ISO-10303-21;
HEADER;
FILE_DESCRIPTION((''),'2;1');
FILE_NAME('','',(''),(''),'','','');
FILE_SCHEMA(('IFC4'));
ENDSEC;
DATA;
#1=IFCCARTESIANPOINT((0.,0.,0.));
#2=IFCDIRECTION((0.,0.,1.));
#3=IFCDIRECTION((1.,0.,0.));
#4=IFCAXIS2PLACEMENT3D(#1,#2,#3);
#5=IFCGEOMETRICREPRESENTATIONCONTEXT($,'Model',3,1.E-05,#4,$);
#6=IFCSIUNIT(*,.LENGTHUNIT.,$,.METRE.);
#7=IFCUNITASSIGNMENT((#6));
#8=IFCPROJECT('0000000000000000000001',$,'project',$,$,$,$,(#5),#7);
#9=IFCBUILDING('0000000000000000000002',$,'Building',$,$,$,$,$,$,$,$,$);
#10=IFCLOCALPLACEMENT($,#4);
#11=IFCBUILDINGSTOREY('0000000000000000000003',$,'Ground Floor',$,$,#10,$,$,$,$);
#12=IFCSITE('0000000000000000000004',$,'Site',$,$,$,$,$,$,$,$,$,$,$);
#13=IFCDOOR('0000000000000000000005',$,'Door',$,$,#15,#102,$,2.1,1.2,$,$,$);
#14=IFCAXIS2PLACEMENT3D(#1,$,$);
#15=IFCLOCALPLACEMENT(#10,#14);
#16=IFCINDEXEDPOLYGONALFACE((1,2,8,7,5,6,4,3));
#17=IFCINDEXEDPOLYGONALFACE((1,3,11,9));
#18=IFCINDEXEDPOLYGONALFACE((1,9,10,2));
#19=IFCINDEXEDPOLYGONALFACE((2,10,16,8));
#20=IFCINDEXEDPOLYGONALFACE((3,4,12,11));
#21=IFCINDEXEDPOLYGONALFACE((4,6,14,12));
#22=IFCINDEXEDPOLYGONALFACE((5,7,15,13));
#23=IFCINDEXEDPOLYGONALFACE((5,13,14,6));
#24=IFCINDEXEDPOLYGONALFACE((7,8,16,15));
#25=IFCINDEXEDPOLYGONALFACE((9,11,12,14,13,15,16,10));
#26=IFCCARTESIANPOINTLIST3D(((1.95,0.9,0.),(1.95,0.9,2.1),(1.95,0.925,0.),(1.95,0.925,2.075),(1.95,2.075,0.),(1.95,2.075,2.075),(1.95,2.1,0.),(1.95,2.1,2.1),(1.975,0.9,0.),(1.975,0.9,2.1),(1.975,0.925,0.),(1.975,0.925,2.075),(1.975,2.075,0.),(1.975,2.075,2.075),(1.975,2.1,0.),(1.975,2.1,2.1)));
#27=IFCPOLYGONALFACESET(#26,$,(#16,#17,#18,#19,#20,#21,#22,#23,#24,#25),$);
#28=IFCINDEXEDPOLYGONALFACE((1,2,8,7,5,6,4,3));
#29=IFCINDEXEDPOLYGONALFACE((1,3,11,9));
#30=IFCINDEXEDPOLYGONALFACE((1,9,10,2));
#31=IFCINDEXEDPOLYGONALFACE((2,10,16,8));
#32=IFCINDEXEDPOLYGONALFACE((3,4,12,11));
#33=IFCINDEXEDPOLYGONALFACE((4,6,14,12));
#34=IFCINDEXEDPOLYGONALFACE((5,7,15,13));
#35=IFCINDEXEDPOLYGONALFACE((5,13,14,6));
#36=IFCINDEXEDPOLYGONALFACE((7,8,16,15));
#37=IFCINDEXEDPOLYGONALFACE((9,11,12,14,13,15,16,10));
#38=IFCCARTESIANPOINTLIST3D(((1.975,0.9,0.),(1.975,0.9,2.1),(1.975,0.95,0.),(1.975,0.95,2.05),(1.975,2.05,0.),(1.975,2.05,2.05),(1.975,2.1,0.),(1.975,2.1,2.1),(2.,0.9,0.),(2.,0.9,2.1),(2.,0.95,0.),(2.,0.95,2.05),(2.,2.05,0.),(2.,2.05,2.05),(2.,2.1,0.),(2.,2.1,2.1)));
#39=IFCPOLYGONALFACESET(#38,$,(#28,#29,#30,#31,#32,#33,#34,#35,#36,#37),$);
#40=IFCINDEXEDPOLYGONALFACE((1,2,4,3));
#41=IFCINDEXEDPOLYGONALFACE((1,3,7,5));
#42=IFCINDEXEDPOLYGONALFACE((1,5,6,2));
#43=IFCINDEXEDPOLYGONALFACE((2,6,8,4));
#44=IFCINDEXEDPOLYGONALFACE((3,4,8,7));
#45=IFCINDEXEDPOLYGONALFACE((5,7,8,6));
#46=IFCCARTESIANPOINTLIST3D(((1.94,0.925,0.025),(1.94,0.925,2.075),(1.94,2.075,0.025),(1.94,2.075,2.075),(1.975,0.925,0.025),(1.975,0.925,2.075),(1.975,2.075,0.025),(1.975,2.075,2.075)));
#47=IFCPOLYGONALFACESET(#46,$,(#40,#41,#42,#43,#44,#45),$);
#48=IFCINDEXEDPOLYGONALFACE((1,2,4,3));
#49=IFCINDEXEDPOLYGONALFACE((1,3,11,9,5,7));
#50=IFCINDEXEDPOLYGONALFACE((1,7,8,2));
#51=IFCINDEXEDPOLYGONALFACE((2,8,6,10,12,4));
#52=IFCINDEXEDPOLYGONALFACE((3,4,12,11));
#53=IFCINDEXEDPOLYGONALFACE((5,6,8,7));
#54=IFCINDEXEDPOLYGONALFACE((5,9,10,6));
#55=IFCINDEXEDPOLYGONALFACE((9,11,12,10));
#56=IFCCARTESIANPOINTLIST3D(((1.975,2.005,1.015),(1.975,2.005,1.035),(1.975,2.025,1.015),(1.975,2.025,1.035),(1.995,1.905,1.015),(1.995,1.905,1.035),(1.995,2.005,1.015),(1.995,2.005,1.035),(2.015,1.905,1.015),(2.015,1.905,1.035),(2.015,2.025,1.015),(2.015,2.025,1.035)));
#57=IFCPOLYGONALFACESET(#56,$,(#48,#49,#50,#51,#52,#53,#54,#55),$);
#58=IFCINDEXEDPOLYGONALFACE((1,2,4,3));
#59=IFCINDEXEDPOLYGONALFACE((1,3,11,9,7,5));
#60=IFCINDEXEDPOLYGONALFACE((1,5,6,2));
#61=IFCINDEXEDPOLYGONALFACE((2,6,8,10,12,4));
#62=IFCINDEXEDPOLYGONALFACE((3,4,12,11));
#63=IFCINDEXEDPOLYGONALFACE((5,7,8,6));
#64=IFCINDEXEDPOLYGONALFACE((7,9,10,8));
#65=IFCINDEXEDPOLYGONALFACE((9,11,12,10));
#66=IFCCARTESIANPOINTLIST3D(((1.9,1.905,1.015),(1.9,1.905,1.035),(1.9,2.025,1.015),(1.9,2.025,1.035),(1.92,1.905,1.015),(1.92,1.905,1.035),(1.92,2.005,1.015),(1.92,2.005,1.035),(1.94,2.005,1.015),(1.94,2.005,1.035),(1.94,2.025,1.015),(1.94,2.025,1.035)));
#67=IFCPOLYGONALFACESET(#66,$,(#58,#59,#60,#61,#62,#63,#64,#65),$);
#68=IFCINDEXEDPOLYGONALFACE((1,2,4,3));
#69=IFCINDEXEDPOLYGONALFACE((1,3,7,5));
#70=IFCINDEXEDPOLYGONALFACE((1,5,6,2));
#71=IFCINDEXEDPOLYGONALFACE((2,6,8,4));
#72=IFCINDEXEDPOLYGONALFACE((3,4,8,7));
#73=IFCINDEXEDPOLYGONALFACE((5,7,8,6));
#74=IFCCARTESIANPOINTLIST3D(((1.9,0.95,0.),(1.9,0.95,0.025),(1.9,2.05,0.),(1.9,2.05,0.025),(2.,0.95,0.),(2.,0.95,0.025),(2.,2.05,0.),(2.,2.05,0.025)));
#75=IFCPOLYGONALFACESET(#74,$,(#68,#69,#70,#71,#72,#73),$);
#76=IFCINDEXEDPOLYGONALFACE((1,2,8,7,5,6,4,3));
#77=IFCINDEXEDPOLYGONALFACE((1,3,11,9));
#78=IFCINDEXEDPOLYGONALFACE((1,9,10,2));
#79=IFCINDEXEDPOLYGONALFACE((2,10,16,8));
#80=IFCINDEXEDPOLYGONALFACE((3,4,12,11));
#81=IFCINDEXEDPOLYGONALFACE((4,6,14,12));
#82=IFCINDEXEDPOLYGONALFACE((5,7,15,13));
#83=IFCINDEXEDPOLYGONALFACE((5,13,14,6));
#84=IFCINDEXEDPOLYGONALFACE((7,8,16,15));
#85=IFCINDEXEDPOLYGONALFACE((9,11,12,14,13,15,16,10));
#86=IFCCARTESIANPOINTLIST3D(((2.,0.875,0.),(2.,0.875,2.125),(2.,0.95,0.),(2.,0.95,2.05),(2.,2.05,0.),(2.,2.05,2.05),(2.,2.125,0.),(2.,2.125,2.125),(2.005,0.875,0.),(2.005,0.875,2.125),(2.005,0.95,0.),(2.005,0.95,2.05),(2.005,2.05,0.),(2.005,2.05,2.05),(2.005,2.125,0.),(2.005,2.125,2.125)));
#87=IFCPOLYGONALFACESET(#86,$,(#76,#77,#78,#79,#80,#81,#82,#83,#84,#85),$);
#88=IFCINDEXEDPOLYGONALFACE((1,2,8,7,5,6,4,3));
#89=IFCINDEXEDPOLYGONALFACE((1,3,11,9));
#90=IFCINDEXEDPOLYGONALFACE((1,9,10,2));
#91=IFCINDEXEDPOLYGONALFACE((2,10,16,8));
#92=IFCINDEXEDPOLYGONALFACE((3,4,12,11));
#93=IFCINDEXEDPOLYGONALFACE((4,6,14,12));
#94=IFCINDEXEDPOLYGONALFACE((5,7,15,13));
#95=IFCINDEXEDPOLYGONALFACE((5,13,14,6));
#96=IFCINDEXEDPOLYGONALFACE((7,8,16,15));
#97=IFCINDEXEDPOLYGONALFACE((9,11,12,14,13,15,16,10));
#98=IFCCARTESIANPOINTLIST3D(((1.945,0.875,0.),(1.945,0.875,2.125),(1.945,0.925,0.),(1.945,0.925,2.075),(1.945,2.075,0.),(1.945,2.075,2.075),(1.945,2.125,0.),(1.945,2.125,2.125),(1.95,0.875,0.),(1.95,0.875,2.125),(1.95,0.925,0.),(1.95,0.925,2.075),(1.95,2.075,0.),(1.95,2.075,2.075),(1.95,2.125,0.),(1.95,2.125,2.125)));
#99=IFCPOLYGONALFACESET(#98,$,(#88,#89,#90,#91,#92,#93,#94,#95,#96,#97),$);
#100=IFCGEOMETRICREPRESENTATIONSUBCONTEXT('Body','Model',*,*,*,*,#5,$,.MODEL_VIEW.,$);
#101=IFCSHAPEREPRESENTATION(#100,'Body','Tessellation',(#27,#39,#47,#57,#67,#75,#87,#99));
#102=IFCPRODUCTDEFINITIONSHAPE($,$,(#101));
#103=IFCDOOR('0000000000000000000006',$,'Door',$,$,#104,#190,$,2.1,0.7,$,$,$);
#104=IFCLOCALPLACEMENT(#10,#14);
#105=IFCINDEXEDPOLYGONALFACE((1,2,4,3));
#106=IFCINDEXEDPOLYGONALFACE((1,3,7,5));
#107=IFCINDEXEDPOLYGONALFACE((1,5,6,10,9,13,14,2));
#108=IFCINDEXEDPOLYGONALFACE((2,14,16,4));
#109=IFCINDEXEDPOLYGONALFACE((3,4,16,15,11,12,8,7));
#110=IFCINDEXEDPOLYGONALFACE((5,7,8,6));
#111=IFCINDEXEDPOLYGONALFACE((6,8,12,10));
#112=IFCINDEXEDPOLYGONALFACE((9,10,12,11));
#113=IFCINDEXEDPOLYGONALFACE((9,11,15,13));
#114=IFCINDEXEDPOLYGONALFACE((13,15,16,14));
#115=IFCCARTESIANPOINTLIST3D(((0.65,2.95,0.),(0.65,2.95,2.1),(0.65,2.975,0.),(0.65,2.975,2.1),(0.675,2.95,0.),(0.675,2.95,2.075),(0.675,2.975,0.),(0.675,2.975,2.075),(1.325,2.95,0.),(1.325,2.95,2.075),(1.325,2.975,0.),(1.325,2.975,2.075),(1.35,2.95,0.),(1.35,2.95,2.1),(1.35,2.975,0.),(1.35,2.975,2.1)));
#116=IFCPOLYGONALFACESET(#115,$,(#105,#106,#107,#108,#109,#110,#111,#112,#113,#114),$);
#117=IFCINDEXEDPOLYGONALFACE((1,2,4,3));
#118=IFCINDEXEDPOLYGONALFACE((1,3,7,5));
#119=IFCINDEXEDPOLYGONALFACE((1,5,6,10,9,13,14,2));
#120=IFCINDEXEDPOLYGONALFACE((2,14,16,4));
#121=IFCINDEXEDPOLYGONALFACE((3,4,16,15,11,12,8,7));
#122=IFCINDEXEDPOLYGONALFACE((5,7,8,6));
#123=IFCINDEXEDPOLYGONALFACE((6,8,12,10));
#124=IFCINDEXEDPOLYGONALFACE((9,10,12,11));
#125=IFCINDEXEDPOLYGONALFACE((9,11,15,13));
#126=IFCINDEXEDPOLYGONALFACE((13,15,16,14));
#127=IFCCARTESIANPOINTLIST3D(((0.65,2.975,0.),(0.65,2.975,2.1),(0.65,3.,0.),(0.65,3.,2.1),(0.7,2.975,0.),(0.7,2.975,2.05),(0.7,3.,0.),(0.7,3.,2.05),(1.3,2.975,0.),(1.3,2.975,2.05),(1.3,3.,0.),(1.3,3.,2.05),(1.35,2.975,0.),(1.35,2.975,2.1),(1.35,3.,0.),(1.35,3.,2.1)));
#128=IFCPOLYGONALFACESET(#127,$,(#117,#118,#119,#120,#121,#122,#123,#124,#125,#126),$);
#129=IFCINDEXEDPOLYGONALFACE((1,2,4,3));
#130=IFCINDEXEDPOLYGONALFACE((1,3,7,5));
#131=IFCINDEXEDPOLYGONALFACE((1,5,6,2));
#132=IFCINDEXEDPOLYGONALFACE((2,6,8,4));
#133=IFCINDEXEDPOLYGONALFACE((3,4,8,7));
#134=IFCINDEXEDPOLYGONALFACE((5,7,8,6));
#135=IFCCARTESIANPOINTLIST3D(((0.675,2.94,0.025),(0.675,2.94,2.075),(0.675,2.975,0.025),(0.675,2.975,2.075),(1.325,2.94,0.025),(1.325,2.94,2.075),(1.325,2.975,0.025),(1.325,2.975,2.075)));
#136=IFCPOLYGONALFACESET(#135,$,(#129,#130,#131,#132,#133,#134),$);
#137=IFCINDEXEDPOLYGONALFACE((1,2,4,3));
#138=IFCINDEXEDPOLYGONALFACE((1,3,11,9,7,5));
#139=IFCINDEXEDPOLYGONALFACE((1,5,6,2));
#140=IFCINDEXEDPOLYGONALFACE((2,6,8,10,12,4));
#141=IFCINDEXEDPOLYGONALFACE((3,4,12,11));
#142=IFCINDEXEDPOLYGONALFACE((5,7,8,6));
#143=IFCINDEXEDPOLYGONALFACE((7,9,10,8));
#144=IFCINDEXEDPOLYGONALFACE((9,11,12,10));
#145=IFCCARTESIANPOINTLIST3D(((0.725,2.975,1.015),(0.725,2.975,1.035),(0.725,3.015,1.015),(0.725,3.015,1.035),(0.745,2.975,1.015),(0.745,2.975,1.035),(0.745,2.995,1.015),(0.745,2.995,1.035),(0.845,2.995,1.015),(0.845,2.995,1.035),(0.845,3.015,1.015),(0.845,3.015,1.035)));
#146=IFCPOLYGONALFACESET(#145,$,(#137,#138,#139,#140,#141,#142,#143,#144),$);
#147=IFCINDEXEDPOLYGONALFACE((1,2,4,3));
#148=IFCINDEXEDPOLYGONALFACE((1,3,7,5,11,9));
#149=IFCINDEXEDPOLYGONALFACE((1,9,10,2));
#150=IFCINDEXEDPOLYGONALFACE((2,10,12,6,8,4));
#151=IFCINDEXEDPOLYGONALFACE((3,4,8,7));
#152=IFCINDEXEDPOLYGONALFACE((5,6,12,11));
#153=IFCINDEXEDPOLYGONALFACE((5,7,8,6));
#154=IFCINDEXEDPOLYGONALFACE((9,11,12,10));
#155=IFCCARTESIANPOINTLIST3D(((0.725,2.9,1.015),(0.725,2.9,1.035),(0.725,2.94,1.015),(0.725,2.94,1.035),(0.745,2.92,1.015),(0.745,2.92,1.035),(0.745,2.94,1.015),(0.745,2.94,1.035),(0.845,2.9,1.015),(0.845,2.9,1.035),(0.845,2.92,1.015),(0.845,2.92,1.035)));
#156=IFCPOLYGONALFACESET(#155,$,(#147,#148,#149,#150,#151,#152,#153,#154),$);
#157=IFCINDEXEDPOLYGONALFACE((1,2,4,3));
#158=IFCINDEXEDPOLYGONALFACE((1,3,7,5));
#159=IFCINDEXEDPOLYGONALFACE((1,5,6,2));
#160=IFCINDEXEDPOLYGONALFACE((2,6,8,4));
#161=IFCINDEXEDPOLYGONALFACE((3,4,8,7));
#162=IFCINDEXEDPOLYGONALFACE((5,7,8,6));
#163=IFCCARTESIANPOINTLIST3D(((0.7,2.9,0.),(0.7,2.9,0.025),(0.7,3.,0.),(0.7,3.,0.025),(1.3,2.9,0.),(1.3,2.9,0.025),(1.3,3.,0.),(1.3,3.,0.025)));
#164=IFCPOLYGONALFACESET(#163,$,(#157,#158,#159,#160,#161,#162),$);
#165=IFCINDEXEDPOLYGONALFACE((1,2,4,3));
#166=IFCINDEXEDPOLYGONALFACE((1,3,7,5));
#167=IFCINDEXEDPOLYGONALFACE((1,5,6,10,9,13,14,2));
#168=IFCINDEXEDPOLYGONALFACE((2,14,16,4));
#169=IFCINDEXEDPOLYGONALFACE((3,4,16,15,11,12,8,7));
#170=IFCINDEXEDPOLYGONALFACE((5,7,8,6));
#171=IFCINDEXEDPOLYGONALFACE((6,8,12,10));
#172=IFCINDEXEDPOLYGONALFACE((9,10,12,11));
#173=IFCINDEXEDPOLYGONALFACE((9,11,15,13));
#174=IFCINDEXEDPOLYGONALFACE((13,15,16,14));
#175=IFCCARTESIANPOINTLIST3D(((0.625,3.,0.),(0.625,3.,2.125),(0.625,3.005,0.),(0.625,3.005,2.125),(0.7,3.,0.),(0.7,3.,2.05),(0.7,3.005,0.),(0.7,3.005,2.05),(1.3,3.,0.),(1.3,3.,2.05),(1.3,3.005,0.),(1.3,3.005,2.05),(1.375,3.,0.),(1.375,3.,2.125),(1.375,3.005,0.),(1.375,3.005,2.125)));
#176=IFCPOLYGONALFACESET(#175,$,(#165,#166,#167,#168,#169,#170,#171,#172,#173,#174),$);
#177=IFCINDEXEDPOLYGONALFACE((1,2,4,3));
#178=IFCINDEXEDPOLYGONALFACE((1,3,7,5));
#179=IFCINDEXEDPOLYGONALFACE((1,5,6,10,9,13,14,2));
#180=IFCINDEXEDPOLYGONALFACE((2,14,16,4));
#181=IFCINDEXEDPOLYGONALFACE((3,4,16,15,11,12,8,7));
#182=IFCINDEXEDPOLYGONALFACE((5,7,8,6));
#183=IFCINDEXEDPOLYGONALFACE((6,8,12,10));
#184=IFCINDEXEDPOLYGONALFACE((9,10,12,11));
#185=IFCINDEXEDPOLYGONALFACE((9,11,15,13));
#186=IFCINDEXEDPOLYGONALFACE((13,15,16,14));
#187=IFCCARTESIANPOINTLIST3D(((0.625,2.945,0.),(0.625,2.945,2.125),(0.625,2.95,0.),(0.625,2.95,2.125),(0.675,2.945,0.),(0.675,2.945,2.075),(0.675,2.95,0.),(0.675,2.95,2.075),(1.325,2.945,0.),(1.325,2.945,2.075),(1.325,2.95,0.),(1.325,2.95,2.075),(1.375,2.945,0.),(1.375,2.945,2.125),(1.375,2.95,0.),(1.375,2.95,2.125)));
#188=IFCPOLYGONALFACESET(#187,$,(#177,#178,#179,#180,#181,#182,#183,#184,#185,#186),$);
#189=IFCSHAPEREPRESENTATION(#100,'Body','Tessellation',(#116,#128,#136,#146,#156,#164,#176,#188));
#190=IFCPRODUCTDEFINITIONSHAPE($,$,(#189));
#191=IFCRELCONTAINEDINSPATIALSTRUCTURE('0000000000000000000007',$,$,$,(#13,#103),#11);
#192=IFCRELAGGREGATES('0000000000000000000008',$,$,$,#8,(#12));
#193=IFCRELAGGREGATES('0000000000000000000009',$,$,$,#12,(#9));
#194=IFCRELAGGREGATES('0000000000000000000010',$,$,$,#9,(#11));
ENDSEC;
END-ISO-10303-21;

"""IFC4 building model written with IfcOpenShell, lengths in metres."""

from ifc_helpers import new_model, si_unit, frame, origin_with_axes, place, context, subcontext, project, spatial, line, indexed_curve, outline, extrude, element, save


model = new_model("IFC4")

# Units and contexts
model_context = context("Model", 3, precision=1e-05, world=origin_with_axes())
body_context = subcontext(model_context, "Body", "Model", "MODEL_VIEW")
ifc_project = project(units=[si_unit("LENGTHUNIT", "METRE")], contexts=[model_context])

# Site, building, storey
site = spatial("IfcSite", under=ifc_project, Name="Site")
building = spatial("IfcBuilding", under=site, Name="Building")
storey_placement = place(None, origin_with_axes())
storey = spatial("IfcBuildingStorey", under=building, at=storey_placement, Name="Ground Floor")

# Doors
door_1_placement = place(storey_placement, frame((2.0, 0.9, 0.0), z_axis=(0.0, 0.0, 1.0), x_axis=(0.0, 1.0, 0.0)))
element("IfcDoor", 1, at=door_1_placement, inside=storey, Name="Door", OverallHeight=2.1, OverallWidth=1.2, context=body_context, shape_type="SweptSolid", body=[
    extrude(outline(indexed_curve([(0.0, 0.0), (0.0, 2.1), (1.2, 2.1), (1.2, 0.0), (1.175, 0.0), (1.175, 2.075), (0.025, 2.075), (0.025, 0.0)], segments=[line(1, 2, 3, 4, 5, 6, 7, 8, 1)])), frame((0.0, 0.025, 0.0), z_axis=(0.0, -1.0, 0.0), x_axis=(1.0, 0.0, 0.0)), (0.0, 0.0, -1.0), 0.025),
    extrude(outline(indexed_curve([(0.0, 0.0), (0.0, 2.1), (1.2, 2.1), (1.2, 0.0), (1.15, 0.0), (1.15, 2.05), (0.05, 2.05), (0.05, 0.0)], segments=[line(1, 2, 3, 4, 5, 6, 7, 8, 1)])), frame((0.0, 0.0, 0.0), z_axis=(0.0, -1.0, 0.0), x_axis=(1.0, 0.0, 0.0)), (0.0, 0.0, -1.0), 0.025),
    extrude(outline(indexed_curve([(0.0, 0.0), (1.15, 0.0), (1.15, 0.035), (0.0, 0.035)], segments=[line(1, 2, 3, 4, 1)])), frame((0.025, 0.025, 0.025), z_axis=(0.0, 0.0, 1.0), x_axis=(1.0, 0.0, 0.0)), (0.0, 0.0, 1.0), 2.05),
    extrude(outline(indexed_curve([(0.0, 0.0), (0.0, -0.04), (-0.12, -0.04), (-0.12, -0.02), (-0.02, -0.02), (-0.02, 0.0)], segments=[line(1, 2, 3, 4, 5, 6, 1)])), frame((1.125, 0.025, 1.015), z_axis=(0.0, 0.0, 1.0), x_axis=(1.0, 0.0, 0.0)), (0.0, 0.0, 1.0), 0.02),
    extrude(outline(indexed_curve([(0.0, 0.0), (0.0, 0.04), (-0.12, 0.04), (-0.12, 0.02), (-0.02, 0.02), (-0.02, 0.0)], segments=[line(1, 2, 3, 4, 5, 6, 1)])), frame((1.125, 0.06, 1.015), z_axis=(0.0, 0.0, 1.0), x_axis=(1.0, 0.0, 0.0)), (0.0, 0.0, 1.0), 0.02),
    extrude(outline(indexed_curve([(0.0, 0.0), (1.1, 0.0), (1.1, 0.1), (0.0, 0.1)], segments=[line(1, 2, 3, 4, 1)])), frame((0.05, 0.0, 0.0), z_axis=(0.0, 0.0, 1.0), x_axis=(1.0, 0.0, 0.0)), (0.0, 0.0, 1.0), 0.025),
    extrude(outline(indexed_curve([(0.0, 0.0), (0.0, 2.125), (1.25, 2.125), (1.25, 0.0), (1.175, 0.0), (1.175, 2.05), (0.075, 2.05), (0.075, 0.0)], segments=[line(1, 2, 3, 4, 5, 6, 7, 8, 1)])), frame((-0.025, -0.005, 0.0), z_axis=(0.0, -1.0, 0.0), x_axis=(1.0, 0.0, 0.0)), (0.0, 0.0, -1.0), 0.005),
    extrude(outline(indexed_curve([(0.0, 0.0), (0.0, 2.125), (1.25, 2.125), (1.25, 0.0), (1.2, 0.0), (1.2, 2.075), (0.05, 2.075), (0.05, 0.0)], segments=[line(1, 2, 3, 4, 5, 6, 7, 8, 1)])), frame((-0.025, 0.05, 0.0), z_axis=(0.0, -1.0, 0.0), x_axis=(1.0, 0.0, 0.0)), (0.0, 0.0, -1.0), 0.005),
])
door_2_placement = place(storey_placement, frame((1.35, 3.0, 0.0), z_axis=(0.0, 0.0, 1.0), x_axis=(-1.0, 0.0, 0.0)))
element("IfcDoor", 2, at=door_2_placement, inside=storey, Name="Door", OverallHeight=2.1, OverallWidth=0.7, context=body_context, shape_type="SweptSolid", body=[
    extrude(outline(indexed_curve([(0.0, 0.0), (0.0, 2.1), (0.7, 2.1), (0.7, 0.0), (0.675, 0.0), (0.675, 2.075), (0.025, 2.075), (0.025, 0.0)], segments=[line(1, 2, 3, 4, 5, 6, 7, 8, 1)])), frame((0.0, 0.025, 0.0), z_axis=(0.0, -1.0, 0.0), x_axis=(1.0, 0.0, 0.0)), (0.0, 0.0, -1.0), 0.025),
    extrude(outline(indexed_curve([(0.0, 0.0), (0.0, 2.1), (0.7, 2.1), (0.7, 0.0), (0.65, 0.0), (0.65, 2.05), (0.05, 2.05), (0.05, 0.0)], segments=[line(1, 2, 3, 4, 5, 6, 7, 8, 1)])), frame((0.0, 0.0, 0.0), z_axis=(0.0, -1.0, 0.0), x_axis=(1.0, 0.0, 0.0)), (0.0, 0.0, -1.0), 0.025),
    extrude(outline(indexed_curve([(0.0, 0.0), (0.65, 0.0), (0.65, 0.035), (0.0, 0.035)], segments=[line(1, 2, 3, 4, 1)])), frame((0.025, 0.025, 0.025), z_axis=(0.0, 0.0, 1.0), x_axis=(1.0, 0.0, 0.0)), (0.0, 0.0, 1.0), 2.05),
    extrude(outline(indexed_curve([(0.0, 0.0), (0.0, -0.04), (-0.12, -0.04), (-0.12, -0.02), (-0.02, -0.02), (-0.02, 0.0)], segments=[line(1, 2, 3, 4, 5, 6, 1)])), frame((0.625, 0.025, 1.015), z_axis=(0.0, 0.0, 1.0), x_axis=(1.0, 0.0, 0.0)), (0.0, 0.0, 1.0), 0.02),
    extrude(outline(indexed_curve([(0.0, 0.0), (0.0, 0.04), (-0.12, 0.04), (-0.12, 0.02), (-0.02, 0.02), (-0.02, 0.0)], segments=[line(1, 2, 3, 4, 5, 6, 1)])), frame((0.625, 0.06, 1.015), z_axis=(0.0, 0.0, 1.0), x_axis=(1.0, 0.0, 0.0)), (0.0, 0.0, 1.0), 0.02),
    extrude(outline(indexed_curve([(0.0, 0.0), (0.6, 0.0), (0.6, 0.1), (0.0, 0.1)], segments=[line(1, 2, 3, 4, 1)])), frame((0.05, 0.0, 0.0), z_axis=(0.0, 0.0, 1.0), x_axis=(1.0, 0.0, 0.0)), (0.0, 0.0, 1.0), 0.025),
    extrude(outline(indexed_curve([(0.0, 0.0), (0.0, 2.125), (0.75, 2.125), (0.75, 0.0), (0.675, 0.0), (0.675, 2.05), (0.075, 2.05), (0.075, 0.0)], segments=[line(1, 2, 3, 4, 5, 6, 7, 8, 1)])), frame((-0.025, -0.005, 0.0), z_axis=(0.0, -1.0, 0.0), x_axis=(1.0, 0.0, 0.0)), (0.0, 0.0, -1.0), 0.005),
    extrude(outline(indexed_curve([(0.0, 0.0), (0.0, 2.125), (0.75, 2.125), (0.75, 0.0), (0.7, 0.0), (0.7, 2.075), (0.05, 2.075), (0.05, 0.0)], segments=[line(1, 2, 3, 4, 5, 6, 7, 8, 1)])), frame((-0.025, 0.05, 0.0), z_axis=(0.0, -1.0, 0.0), x_axis=(1.0, 0.0, 0.0)), (0.0, 0.0, -1.0), 0.005),
])

save(model, "model.ifc")
